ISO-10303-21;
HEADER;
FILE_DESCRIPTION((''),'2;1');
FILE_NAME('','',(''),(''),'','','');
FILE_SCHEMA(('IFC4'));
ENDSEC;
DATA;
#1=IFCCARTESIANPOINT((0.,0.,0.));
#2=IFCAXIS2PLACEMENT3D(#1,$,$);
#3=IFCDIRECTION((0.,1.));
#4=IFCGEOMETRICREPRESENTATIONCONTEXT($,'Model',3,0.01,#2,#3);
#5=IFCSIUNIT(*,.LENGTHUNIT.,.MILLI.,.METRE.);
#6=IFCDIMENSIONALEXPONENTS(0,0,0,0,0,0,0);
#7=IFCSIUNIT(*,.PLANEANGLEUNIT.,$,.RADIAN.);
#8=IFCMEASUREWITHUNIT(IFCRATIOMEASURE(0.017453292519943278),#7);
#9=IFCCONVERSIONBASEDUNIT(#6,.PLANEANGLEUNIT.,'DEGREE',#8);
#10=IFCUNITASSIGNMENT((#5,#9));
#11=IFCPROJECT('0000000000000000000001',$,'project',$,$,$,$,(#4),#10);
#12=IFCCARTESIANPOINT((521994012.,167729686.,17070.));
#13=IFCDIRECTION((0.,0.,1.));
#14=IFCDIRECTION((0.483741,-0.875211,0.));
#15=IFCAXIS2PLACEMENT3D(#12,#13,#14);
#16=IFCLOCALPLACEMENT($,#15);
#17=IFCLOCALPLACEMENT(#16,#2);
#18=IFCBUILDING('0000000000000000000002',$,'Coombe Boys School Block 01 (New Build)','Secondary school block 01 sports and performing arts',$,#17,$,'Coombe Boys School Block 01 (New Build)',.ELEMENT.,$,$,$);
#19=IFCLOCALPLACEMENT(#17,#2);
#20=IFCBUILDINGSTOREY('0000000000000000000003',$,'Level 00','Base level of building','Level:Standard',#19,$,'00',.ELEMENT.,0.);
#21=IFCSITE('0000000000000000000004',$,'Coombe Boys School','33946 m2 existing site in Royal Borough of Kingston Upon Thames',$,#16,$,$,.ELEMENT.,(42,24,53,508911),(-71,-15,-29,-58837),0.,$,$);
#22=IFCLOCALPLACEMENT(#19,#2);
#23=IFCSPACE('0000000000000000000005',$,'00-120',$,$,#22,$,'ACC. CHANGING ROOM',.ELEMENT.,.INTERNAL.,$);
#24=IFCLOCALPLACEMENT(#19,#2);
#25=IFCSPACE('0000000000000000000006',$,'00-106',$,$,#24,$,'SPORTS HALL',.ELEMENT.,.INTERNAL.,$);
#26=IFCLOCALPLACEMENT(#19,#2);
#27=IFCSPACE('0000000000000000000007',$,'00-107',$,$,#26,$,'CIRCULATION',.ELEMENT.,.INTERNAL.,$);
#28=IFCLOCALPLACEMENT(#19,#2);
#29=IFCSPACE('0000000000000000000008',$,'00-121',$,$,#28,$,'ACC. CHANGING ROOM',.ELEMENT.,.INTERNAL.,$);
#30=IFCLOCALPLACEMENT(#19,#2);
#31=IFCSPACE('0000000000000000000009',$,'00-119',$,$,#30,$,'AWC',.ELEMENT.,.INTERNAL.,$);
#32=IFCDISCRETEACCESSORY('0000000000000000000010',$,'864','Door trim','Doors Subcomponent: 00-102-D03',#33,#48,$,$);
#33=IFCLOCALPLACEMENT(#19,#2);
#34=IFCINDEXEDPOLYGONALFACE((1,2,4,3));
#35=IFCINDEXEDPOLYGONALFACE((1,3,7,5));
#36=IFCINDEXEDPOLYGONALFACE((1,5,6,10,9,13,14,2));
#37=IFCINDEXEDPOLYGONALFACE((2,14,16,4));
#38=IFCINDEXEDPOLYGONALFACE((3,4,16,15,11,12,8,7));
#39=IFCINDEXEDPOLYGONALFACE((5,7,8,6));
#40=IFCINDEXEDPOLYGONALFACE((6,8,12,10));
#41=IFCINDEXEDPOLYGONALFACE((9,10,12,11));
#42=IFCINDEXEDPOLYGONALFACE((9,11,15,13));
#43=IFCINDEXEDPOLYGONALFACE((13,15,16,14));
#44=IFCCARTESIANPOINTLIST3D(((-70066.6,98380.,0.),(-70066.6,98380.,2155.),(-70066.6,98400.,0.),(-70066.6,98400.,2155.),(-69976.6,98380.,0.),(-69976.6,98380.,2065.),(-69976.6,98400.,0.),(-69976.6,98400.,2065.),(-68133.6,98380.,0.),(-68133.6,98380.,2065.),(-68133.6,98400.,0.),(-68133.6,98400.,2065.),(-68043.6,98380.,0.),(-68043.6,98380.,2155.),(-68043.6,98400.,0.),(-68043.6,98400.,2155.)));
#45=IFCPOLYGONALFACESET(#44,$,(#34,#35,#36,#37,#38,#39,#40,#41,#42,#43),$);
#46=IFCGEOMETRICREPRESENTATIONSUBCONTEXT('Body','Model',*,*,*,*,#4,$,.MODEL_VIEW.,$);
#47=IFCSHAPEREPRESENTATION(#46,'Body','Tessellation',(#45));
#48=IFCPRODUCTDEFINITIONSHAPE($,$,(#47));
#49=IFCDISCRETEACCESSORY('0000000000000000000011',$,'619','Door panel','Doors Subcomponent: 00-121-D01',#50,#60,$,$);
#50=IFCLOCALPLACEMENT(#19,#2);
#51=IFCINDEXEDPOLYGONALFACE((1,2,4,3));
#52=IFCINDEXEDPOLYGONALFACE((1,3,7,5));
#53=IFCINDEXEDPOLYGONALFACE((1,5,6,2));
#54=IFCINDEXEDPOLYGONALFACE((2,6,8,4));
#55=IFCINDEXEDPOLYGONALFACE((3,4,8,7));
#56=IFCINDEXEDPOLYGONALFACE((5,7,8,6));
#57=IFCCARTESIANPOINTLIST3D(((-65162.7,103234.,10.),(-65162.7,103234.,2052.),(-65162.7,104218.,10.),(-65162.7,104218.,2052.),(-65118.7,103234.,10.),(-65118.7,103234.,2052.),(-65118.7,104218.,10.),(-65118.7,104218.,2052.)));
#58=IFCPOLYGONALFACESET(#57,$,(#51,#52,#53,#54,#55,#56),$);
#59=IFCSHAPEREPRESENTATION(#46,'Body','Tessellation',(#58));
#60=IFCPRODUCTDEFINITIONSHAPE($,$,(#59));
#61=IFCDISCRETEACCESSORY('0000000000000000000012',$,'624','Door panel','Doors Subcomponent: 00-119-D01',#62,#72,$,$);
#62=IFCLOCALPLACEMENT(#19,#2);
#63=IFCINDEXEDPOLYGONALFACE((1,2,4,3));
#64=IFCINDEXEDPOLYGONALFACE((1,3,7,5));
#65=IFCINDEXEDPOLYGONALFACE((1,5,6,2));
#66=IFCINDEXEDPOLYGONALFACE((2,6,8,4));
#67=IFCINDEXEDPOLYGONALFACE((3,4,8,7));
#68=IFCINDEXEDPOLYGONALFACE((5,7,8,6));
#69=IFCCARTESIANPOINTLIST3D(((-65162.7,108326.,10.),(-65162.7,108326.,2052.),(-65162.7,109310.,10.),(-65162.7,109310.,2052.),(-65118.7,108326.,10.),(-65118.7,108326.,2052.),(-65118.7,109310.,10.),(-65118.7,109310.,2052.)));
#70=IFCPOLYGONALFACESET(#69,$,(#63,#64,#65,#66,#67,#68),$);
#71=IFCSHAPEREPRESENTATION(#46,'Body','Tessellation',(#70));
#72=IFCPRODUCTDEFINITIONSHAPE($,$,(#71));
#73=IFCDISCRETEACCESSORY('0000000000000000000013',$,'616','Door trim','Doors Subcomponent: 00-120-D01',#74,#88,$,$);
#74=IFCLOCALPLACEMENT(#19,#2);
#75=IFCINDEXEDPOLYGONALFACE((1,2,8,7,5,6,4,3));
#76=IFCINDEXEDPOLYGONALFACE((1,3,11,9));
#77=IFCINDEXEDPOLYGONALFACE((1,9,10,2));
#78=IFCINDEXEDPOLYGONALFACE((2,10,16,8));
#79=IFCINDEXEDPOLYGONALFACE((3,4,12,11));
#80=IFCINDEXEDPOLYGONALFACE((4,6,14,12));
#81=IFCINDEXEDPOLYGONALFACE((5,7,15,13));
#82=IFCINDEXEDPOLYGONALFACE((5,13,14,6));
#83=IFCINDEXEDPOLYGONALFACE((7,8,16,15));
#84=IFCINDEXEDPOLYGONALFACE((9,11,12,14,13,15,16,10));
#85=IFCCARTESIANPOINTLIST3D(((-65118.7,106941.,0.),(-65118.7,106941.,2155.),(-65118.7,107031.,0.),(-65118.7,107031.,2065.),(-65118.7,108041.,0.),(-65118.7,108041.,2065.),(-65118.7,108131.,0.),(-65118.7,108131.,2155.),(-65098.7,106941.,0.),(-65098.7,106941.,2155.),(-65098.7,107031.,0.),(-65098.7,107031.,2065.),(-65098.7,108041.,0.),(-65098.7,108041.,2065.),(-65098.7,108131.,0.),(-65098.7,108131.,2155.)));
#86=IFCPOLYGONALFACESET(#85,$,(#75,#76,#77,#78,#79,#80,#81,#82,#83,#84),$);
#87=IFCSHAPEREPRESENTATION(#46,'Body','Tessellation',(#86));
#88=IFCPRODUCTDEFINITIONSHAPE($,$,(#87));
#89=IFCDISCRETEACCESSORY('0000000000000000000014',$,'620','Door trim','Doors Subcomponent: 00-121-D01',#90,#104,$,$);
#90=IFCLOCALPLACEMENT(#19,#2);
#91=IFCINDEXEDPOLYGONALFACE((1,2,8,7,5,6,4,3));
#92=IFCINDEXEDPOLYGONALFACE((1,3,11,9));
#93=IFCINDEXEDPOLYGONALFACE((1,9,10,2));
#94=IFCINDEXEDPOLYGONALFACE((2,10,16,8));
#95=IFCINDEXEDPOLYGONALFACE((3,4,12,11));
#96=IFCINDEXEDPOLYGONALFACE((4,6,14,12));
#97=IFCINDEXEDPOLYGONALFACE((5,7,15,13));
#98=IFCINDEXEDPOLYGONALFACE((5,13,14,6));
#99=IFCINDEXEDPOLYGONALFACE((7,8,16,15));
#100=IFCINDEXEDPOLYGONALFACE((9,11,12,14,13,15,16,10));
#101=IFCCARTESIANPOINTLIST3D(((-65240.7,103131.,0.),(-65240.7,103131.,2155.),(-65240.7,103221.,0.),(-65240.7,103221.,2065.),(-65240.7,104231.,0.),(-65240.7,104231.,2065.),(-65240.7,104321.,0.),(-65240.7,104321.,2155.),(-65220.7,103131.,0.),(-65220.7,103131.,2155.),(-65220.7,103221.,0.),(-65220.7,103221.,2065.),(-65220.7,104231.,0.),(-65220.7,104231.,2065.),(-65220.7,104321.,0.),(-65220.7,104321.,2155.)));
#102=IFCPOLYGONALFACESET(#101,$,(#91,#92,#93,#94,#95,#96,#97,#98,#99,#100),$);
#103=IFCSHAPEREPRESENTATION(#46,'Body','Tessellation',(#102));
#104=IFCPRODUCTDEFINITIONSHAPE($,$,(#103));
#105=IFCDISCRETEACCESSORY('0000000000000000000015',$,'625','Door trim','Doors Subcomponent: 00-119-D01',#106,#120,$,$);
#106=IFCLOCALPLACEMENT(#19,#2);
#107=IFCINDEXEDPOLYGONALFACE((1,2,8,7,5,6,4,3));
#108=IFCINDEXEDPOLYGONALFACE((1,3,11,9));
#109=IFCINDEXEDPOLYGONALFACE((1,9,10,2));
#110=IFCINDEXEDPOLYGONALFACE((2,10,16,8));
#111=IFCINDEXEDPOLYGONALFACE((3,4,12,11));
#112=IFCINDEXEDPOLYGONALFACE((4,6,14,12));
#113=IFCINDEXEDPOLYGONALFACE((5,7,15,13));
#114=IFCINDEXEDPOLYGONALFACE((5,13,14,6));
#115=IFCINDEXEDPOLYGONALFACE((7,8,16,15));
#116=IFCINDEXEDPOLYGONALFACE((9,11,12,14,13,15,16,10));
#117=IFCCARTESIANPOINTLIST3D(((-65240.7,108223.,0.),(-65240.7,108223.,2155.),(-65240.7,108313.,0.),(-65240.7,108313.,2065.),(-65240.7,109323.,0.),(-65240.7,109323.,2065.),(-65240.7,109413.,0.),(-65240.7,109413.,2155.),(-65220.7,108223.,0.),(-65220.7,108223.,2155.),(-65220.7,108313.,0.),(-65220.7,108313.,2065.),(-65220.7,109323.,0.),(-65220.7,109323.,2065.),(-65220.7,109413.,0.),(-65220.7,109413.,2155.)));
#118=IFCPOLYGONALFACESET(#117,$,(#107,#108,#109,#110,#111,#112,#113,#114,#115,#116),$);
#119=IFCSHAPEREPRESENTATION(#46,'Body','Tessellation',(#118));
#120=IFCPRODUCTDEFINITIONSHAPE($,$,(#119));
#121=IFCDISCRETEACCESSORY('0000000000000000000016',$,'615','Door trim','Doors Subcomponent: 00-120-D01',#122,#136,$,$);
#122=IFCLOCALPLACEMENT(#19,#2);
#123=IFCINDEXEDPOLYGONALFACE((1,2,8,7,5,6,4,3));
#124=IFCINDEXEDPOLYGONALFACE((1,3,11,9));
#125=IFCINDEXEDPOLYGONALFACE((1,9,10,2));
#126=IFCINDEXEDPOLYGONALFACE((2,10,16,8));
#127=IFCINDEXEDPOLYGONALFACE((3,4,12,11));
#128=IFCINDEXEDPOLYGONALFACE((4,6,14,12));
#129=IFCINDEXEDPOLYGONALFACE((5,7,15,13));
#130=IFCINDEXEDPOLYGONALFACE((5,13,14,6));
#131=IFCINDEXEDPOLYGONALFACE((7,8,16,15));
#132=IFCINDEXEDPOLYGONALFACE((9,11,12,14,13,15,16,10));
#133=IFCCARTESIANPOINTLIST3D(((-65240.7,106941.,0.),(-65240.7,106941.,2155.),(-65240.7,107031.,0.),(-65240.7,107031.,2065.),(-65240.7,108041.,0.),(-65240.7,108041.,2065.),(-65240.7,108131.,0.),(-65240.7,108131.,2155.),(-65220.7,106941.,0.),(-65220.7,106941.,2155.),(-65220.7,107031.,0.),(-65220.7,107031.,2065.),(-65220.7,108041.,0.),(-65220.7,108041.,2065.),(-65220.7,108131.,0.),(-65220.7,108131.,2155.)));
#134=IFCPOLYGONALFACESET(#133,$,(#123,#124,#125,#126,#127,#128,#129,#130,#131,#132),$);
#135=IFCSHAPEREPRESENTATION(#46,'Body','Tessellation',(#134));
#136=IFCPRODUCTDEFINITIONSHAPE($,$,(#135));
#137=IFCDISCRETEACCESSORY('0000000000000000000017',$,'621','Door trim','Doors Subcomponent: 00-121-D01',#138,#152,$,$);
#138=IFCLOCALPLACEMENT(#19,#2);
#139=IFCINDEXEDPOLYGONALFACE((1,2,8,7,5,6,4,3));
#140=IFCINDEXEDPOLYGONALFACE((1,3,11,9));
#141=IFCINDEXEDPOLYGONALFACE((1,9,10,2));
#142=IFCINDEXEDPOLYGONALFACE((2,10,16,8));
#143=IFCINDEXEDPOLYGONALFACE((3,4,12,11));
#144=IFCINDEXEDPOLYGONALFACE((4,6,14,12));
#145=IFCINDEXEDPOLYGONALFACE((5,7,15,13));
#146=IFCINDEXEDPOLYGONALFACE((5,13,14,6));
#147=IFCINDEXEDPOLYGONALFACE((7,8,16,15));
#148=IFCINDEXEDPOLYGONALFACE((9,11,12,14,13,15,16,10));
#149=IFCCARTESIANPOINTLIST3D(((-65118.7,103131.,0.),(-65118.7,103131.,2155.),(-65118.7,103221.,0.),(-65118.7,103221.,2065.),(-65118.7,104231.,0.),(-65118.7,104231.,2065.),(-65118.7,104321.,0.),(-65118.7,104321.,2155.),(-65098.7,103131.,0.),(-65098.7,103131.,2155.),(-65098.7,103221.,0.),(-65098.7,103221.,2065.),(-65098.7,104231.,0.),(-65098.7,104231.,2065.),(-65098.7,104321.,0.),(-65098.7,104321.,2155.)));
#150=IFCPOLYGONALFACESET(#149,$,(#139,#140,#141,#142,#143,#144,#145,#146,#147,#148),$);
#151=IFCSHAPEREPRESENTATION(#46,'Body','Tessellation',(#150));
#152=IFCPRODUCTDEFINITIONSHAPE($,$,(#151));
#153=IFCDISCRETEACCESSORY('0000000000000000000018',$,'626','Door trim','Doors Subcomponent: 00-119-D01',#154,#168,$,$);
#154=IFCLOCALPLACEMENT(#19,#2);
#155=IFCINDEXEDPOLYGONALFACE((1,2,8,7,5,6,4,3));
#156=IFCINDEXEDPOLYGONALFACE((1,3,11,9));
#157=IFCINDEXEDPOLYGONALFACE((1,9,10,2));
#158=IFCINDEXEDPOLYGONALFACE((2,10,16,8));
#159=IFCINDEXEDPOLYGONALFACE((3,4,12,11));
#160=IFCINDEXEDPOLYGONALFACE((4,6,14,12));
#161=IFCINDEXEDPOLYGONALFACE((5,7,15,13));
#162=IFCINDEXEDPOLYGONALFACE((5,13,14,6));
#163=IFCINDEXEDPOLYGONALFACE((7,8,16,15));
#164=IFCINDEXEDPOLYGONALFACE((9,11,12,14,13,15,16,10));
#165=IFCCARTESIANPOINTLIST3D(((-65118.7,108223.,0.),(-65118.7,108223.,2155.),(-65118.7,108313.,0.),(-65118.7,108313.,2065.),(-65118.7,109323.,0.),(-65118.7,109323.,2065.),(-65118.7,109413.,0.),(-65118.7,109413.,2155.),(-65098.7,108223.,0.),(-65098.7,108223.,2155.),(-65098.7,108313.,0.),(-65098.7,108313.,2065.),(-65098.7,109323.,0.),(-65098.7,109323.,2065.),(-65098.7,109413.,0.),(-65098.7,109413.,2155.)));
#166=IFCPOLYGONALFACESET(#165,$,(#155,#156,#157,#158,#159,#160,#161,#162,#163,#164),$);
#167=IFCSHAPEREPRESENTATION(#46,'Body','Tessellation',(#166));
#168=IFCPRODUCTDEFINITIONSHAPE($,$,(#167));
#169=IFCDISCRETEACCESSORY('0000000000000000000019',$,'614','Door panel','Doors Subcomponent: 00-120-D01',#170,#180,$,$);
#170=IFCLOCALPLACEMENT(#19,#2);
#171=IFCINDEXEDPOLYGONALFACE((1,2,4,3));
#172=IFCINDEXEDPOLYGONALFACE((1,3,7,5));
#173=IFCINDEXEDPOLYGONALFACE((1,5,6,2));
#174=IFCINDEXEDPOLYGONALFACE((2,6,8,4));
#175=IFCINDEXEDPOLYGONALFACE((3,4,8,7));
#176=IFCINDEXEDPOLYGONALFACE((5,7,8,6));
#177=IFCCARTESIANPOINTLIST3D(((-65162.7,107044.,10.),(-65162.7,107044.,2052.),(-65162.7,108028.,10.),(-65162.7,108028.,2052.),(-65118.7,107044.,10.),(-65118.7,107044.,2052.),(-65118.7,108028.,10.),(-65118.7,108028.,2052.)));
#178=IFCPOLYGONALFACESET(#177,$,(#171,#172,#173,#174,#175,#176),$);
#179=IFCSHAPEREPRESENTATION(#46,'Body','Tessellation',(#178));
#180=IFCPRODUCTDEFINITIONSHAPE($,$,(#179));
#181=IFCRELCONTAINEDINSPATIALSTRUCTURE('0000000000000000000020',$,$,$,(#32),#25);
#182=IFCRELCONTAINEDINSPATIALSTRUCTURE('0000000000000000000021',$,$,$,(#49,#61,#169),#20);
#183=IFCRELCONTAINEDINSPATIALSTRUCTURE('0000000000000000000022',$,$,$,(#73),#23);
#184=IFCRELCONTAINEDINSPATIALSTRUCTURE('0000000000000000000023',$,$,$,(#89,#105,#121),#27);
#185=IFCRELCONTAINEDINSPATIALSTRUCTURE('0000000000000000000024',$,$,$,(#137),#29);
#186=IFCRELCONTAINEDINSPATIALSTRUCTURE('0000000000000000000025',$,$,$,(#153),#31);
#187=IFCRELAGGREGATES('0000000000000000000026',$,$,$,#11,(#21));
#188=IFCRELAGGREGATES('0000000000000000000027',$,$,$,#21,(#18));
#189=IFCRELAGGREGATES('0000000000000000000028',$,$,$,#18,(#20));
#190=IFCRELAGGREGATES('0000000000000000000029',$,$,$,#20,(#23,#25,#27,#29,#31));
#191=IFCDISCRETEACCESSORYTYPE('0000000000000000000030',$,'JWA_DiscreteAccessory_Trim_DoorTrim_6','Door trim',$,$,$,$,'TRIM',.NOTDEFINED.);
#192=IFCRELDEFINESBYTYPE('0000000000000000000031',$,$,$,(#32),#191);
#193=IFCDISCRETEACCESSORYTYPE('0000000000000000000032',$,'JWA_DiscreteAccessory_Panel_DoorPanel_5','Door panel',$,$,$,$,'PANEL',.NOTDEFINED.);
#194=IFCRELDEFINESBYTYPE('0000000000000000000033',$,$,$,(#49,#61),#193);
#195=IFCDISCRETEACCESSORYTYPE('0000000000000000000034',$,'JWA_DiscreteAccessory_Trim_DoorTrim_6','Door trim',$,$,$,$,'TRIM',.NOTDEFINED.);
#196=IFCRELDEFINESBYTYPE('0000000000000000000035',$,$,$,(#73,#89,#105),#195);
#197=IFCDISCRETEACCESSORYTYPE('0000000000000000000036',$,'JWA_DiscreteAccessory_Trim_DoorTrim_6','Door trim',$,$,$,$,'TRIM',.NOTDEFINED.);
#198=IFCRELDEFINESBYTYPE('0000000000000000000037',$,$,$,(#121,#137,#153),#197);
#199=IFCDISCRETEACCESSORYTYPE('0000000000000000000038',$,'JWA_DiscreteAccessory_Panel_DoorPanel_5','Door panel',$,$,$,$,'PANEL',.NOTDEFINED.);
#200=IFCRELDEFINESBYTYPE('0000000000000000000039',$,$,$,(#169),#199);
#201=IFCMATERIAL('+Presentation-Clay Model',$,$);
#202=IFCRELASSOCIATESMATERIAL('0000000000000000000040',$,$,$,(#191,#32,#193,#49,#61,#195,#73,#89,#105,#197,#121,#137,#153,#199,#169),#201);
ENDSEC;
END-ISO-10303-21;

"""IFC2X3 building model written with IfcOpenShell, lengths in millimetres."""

from ifc_helpers import new_model, entity, si_unit, converted_unit, direction, frame, origin, origin_2d_with_axis, place, context, subcontext, project, spatial, polyline, rectangle, outline, extrude, source, transform, mapped, material, type_object, type_shapes, element, save


model = new_model("IFC2X3")

# Units and contexts
model_context = context("Model", 3, precision=0.01, world=origin(), true_north=direction((0.0, 1.0)))
body_context = subcontext(model_context, "Body", "Model", "MODEL_VIEW")
ifc_project = project(units=[si_unit("LENGTHUNIT", "METRE", prefix="MILLI"), converted_unit("PLANEANGLEUNIT", "DEGREE", entity("IfcRatioMeasure", 0.017453292519943278), si_unit("PLANEANGLEUNIT", "RADIAN"), dimensions=[0, 0, 0, 0, 0, 0, 0])], contexts=[model_context])

# Site, building, storey
site_placement = place(None, frame((521994012.0, 167729686.0, 17070.0), z_axis=(0.0, 0.0, 1.0), x_axis=(0.483741, -0.875211, 0.0)))
site = spatial("IfcSite", under=ifc_project, at=site_placement, Name="Coombe Boys School", Description="33946 m2 existing site in Royal Borough of Kingston Upon Thames", CompositionType="ELEMENT", RefLatitude=(42, 24, 53, 508911), RefLongitude=(-71, -15, -29, -58837), RefElevation=0.0)
building_placement = place(site_placement, origin())
building = spatial("IfcBuilding", under=site, at=building_placement, Name="Coombe Boys School Block 01 (New Build)", Description="Secondary school block 01 sports and performing arts", LongName="Coombe Boys School Block 01 (New Build)", CompositionType="ELEMENT")
storey_placement = place(building_placement, origin())
storey = spatial("IfcBuildingStorey", under=building, at=storey_placement, Name="Level 00", Description="Base level of building", ObjectType="Level:Standard", LongName="00", CompositionType="ELEMENT", Elevation=0.0)

# Shared definitions
space_1_placement = place(storey_placement, origin())
space_1 = spatial("IfcSpace", under=storey, at=space_1_placement, Name="00-120", LongName="ACC. CHANGING ROOM", CompositionType="ELEMENT", InteriorOrExteriorSpace="INTERNAL")

# Shared definitions
space_2_placement = place(storey_placement, origin())
space_2 = spatial("IfcSpace", under=storey, at=space_2_placement, Name="00-106", LongName="SPORTS HALL", CompositionType="ELEMENT", InteriorOrExteriorSpace="INTERNAL")

# Discrete accessories
ifc_material_1 = material(Name="+Presentation-Clay Model")
discrete_accessory_type_1 = type_object("IfcDiscreteAccessoryType", Name="JWA_DiscreteAccessory_Trim_DoorTrim_6", Description="Door trim", ElementType="TRIM", material=ifc_material_1)
shared_shape_1 = source(origin(), body_context, "Body", "SweptSolid", [
    extrude(outline(polyline([(921.5, -1055.0), (1011.5, -1055.0), (1011.5, 1100.0), (-1011.5, 1100.0), (-1011.5, -1055.0), (-921.5, -1055.0), (-921.5, 1010.0), (921.5, 1010.0), (921.5, -1055.0)])), frame((0.0, 0.0, 1055.0), z_axis=(0.0, 1.0, 0.0), x_axis=(-1.0, 0.0, 0.0)), (0.0, 0.0, 1.0), 20.0),
])
type_shapes(discrete_accessory_type_1, [shared_shape_1])
discrete_accessory_1_placement = place(space_2_placement, frame((-69055.1, 98380.0, 0.0)))
element("IfcDiscreteAccessory", 1, at=discrete_accessory_1_placement, inside=space_2, type_object=discrete_accessory_type_1, material=ifc_material_1, Name="864", Description="Door trim", ObjectType="Doors Subcomponent: 00-102-D03", context=body_context, shape_type="MappedRepresentation", body=[
    mapped(shared_shape_1, transform((0.0, 0.0, 0.0), scale=1.0)),
])
discrete_accessory_type_2 = type_object("IfcDiscreteAccessoryType", Name="JWA_DiscreteAccessory_Panel_DoorPanel_5", Description="Door panel", ElementType="PANEL", material=ifc_material_1)
shared_shape_2 = source(origin(), body_context, "Body", "SweptSolid", [
    extrude(rectangle(XDim=44.0, YDim=984.0, at=origin_2d_with_axis()), frame((0.0, 22.0, 10.0), z_axis=(0.0, 0.0, 1.0), x_axis=(0.0, -1.0, 0.0)), (0.0, 0.0, 1.0), 2042.0),
])
type_shapes(discrete_accessory_type_2, [shared_shape_2])
discrete_accessory_2_placement = place(storey_placement, frame((-65162.7, 103726.0, 0.0), z_axis=(0.0, 0.0, 1.0), x_axis=(0.0, -1.0, 0.0)))
element("IfcDiscreteAccessory", 2, at=discrete_accessory_2_placement, inside=storey, type_object=discrete_accessory_type_2, material=ifc_material_1, Name="619", Description="Door panel", ObjectType="Doors Subcomponent: 00-121-D01", context=body_context, shape_type="MappedRepresentation", body=[
    mapped(shared_shape_2, transform((0.0, 0.0, 0.0), scale=1.0)),
])
discrete_accessory_3_placement = place(storey_placement, frame((-65162.7, 108818.0, 0.0), z_axis=(0.0, 0.0, 1.0), x_axis=(0.0, -1.0, 0.0)))
element("IfcDiscreteAccessory", 3, at=discrete_accessory_3_placement, inside=storey, type_object=discrete_accessory_type_2, material=ifc_material_1, Name="624", Description="Door panel", ObjectType="Doors Subcomponent: 00-119-D01", context=body_context, shape_type="MappedRepresentation", body=[
    mapped(shared_shape_2, transform((0.0, 0.0, 0.0), scale=1.0)),
])
discrete_accessory_type_3 = type_object("IfcDiscreteAccessoryType", Name="JWA_DiscreteAccessory_Trim_DoorTrim_6", Description="Door trim", ElementType="TRIM", material=ifc_material_1)
shared_shape_3 = source(origin(), body_context, "Body", "SweptSolid", [
    extrude(outline(polyline([(-1055.0, -595.0), (1100.0, -595.0), (1100.0, 595.0), (-1055.0, 595.0), (-1055.0, 505.0), (1010.0, 505.0), (1010.0, -505.0), (-1055.0, -505.0), (-1055.0, -595.0)])), frame((0.0, -20.0, 1055.0), z_axis=(0.0, 1.0, 0.0), x_axis=(0.0, 0.0, 1.0)), (0.0, 0.0, 1.0), 20.0),
])
type_shapes(discrete_accessory_type_3, [shared_shape_3])
discrete_accessory_4_placement = place(space_1_placement, frame((-65118.7, 107536.0, 0.0), z_axis=(0.0, 0.0, 1.0), x_axis=(0.0, 1.0, 0.0)))
element("IfcDiscreteAccessory", 4, at=discrete_accessory_4_placement, inside=space_1, type_object=discrete_accessory_type_3, material=ifc_material_1, Name="616", Description="Door trim", ObjectType="Doors Subcomponent: 00-120-D01", context=body_context, shape_type="MappedRepresentation", body=[
    mapped(shared_shape_3, transform((0.0, 0.0, 0.0), scale=1.0)),
])

# Shared definitions
space_3_placement = place(storey_placement, origin())
space_3 = spatial("IfcSpace", under=storey, at=space_3_placement, Name="00-107", LongName="CIRCULATION", CompositionType="ELEMENT", InteriorOrExteriorSpace="INTERNAL")

# Discrete accessories
discrete_accessory_5_placement = place(space_3_placement, frame((-65220.7, 103726.0, 0.0), z_axis=(0.0, 0.0, 1.0), x_axis=(0.0, -1.0, 0.0)))
element("IfcDiscreteAccessory", 5, at=discrete_accessory_5_placement, inside=space_3, type_object=discrete_accessory_type_3, material=ifc_material_1, Name="620", Description="Door trim", ObjectType="Doors Subcomponent: 00-121-D01", context=body_context, shape_type="MappedRepresentation", body=[
    mapped(shared_shape_3, transform((0.0, 0.0, 0.0), scale=1.0)),
])
discrete_accessory_6_placement = place(space_3_placement, frame((-65220.7, 108818.0, 0.0), z_axis=(0.0, 0.0, 1.0), x_axis=(0.0, -1.0, 0.0)))
element("IfcDiscreteAccessory", 6, at=discrete_accessory_6_placement, inside=space_3, type_object=discrete_accessory_type_3, material=ifc_material_1, Name="625", Description="Door trim", ObjectType="Doors Subcomponent: 00-119-D01", context=body_context, shape_type="MappedRepresentation", body=[
    mapped(shared_shape_3, transform((0.0, 0.0, 0.0), scale=1.0)),
])
discrete_accessory_type_4 = type_object("IfcDiscreteAccessoryType", Name="JWA_DiscreteAccessory_Trim_DoorTrim_6", Description="Door trim", ElementType="TRIM", material=ifc_material_1)
shared_shape_4 = source(origin(), body_context, "Body", "SweptSolid", [
    extrude(outline(polyline([(505.0, -1055.0), (595.0, -1055.0), (595.0, 1100.0), (-595.0, 1100.0), (-595.0, -1055.0), (-505.0, -1055.0), (-505.0, 1010.0), (505.0, 1010.0), (505.0, -1055.0)])), frame((0.0, 0.0, 1055.0), z_axis=(0.0, 1.0, 0.0), x_axis=(-1.0, 0.0, 0.0)), (0.0, 0.0, 1.0), 20.0),
])
type_shapes(discrete_accessory_type_4, [shared_shape_4])
discrete_accessory_7_placement = place(space_3_placement, frame((-65220.7, 107536.0, 0.0), z_axis=(0.0, 0.0, 1.0), x_axis=(0.0, 1.0, 0.0)))
element("IfcDiscreteAccessory", 7, at=discrete_accessory_7_placement, inside=space_3, type_object=discrete_accessory_type_4, material=ifc_material_1, Name="615", Description="Door trim", ObjectType="Doors Subcomponent: 00-120-D01", context=body_context, shape_type="MappedRepresentation", body=[
    mapped(shared_shape_4, transform((0.0, 0.0, 0.0), scale=1.0)),
])

# Shared definitions
space_4_placement = place(storey_placement, origin())
space_4 = spatial("IfcSpace", under=storey, at=space_4_placement, Name="00-121", LongName="ACC. CHANGING ROOM", CompositionType="ELEMENT", InteriorOrExteriorSpace="INTERNAL")

# Discrete accessory
discrete_accessory_8_placement = place(space_4_placement, frame((-65118.7, 103726.0, 0.0), z_axis=(0.0, 0.0, 1.0), x_axis=(0.0, -1.0, 0.0)))
element("IfcDiscreteAccessory", 8, at=discrete_accessory_8_placement, inside=space_4, type_object=discrete_accessory_type_4, material=ifc_material_1, Name="621", Description="Door trim", ObjectType="Doors Subcomponent: 00-121-D01", context=body_context, shape_type="MappedRepresentation", body=[
    mapped(shared_shape_4, transform((0.0, 0.0, 0.0), scale=1.0)),
])

# Shared definitions
space_5_placement = place(storey_placement, origin())
space_5 = spatial("IfcSpace", under=storey, at=space_5_placement, Name="00-119", LongName="AWC", CompositionType="ELEMENT", InteriorOrExteriorSpace="INTERNAL")

# Discrete accessories
discrete_accessory_9_placement = place(space_5_placement, frame((-65118.7, 108818.0, 0.0), z_axis=(0.0, 0.0, 1.0), x_axis=(0.0, -1.0, 0.0)))
element("IfcDiscreteAccessory", 9, at=discrete_accessory_9_placement, inside=space_5, type_object=discrete_accessory_type_4, material=ifc_material_1, Name="626", Description="Door trim", ObjectType="Doors Subcomponent: 00-119-D01", context=body_context, shape_type="MappedRepresentation", body=[
    mapped(shared_shape_4, transform((0.0, 0.0, 0.0), scale=1.0)),
])
discrete_accessory_type_5 = type_object("IfcDiscreteAccessoryType", Name="JWA_DiscreteAccessory_Panel_DoorPanel_5", Description="Door panel", ElementType="PANEL", material=ifc_material_1)
shared_shape_5 = source(origin(), body_context, "Body", "SweptSolid", [
    extrude(rectangle(XDim=984.0, YDim=44.0, at=origin_2d_with_axis()), frame((0.0, -22.0, 10.0)), (0.0, 0.0, 1.0), 2042.0),
])
type_shapes(discrete_accessory_type_5, [shared_shape_5])
discrete_accessory_10_placement = place(storey_placement, frame((-65162.7, 107536.0, 0.0), z_axis=(0.0, 0.0, 1.0), x_axis=(0.0, 1.0, 0.0)))
element("IfcDiscreteAccessory", 10, at=discrete_accessory_10_placement, inside=storey, type_object=discrete_accessory_type_5, material=ifc_material_1, Name="614", Description="Door panel", ObjectType="Doors Subcomponent: 00-120-D01", context=body_context, shape_type="MappedRepresentation", body=[
    mapped(shared_shape_5, transform((0.0, 0.0, 0.0), scale=1.0)),
])

save(model, "model.ifc")
